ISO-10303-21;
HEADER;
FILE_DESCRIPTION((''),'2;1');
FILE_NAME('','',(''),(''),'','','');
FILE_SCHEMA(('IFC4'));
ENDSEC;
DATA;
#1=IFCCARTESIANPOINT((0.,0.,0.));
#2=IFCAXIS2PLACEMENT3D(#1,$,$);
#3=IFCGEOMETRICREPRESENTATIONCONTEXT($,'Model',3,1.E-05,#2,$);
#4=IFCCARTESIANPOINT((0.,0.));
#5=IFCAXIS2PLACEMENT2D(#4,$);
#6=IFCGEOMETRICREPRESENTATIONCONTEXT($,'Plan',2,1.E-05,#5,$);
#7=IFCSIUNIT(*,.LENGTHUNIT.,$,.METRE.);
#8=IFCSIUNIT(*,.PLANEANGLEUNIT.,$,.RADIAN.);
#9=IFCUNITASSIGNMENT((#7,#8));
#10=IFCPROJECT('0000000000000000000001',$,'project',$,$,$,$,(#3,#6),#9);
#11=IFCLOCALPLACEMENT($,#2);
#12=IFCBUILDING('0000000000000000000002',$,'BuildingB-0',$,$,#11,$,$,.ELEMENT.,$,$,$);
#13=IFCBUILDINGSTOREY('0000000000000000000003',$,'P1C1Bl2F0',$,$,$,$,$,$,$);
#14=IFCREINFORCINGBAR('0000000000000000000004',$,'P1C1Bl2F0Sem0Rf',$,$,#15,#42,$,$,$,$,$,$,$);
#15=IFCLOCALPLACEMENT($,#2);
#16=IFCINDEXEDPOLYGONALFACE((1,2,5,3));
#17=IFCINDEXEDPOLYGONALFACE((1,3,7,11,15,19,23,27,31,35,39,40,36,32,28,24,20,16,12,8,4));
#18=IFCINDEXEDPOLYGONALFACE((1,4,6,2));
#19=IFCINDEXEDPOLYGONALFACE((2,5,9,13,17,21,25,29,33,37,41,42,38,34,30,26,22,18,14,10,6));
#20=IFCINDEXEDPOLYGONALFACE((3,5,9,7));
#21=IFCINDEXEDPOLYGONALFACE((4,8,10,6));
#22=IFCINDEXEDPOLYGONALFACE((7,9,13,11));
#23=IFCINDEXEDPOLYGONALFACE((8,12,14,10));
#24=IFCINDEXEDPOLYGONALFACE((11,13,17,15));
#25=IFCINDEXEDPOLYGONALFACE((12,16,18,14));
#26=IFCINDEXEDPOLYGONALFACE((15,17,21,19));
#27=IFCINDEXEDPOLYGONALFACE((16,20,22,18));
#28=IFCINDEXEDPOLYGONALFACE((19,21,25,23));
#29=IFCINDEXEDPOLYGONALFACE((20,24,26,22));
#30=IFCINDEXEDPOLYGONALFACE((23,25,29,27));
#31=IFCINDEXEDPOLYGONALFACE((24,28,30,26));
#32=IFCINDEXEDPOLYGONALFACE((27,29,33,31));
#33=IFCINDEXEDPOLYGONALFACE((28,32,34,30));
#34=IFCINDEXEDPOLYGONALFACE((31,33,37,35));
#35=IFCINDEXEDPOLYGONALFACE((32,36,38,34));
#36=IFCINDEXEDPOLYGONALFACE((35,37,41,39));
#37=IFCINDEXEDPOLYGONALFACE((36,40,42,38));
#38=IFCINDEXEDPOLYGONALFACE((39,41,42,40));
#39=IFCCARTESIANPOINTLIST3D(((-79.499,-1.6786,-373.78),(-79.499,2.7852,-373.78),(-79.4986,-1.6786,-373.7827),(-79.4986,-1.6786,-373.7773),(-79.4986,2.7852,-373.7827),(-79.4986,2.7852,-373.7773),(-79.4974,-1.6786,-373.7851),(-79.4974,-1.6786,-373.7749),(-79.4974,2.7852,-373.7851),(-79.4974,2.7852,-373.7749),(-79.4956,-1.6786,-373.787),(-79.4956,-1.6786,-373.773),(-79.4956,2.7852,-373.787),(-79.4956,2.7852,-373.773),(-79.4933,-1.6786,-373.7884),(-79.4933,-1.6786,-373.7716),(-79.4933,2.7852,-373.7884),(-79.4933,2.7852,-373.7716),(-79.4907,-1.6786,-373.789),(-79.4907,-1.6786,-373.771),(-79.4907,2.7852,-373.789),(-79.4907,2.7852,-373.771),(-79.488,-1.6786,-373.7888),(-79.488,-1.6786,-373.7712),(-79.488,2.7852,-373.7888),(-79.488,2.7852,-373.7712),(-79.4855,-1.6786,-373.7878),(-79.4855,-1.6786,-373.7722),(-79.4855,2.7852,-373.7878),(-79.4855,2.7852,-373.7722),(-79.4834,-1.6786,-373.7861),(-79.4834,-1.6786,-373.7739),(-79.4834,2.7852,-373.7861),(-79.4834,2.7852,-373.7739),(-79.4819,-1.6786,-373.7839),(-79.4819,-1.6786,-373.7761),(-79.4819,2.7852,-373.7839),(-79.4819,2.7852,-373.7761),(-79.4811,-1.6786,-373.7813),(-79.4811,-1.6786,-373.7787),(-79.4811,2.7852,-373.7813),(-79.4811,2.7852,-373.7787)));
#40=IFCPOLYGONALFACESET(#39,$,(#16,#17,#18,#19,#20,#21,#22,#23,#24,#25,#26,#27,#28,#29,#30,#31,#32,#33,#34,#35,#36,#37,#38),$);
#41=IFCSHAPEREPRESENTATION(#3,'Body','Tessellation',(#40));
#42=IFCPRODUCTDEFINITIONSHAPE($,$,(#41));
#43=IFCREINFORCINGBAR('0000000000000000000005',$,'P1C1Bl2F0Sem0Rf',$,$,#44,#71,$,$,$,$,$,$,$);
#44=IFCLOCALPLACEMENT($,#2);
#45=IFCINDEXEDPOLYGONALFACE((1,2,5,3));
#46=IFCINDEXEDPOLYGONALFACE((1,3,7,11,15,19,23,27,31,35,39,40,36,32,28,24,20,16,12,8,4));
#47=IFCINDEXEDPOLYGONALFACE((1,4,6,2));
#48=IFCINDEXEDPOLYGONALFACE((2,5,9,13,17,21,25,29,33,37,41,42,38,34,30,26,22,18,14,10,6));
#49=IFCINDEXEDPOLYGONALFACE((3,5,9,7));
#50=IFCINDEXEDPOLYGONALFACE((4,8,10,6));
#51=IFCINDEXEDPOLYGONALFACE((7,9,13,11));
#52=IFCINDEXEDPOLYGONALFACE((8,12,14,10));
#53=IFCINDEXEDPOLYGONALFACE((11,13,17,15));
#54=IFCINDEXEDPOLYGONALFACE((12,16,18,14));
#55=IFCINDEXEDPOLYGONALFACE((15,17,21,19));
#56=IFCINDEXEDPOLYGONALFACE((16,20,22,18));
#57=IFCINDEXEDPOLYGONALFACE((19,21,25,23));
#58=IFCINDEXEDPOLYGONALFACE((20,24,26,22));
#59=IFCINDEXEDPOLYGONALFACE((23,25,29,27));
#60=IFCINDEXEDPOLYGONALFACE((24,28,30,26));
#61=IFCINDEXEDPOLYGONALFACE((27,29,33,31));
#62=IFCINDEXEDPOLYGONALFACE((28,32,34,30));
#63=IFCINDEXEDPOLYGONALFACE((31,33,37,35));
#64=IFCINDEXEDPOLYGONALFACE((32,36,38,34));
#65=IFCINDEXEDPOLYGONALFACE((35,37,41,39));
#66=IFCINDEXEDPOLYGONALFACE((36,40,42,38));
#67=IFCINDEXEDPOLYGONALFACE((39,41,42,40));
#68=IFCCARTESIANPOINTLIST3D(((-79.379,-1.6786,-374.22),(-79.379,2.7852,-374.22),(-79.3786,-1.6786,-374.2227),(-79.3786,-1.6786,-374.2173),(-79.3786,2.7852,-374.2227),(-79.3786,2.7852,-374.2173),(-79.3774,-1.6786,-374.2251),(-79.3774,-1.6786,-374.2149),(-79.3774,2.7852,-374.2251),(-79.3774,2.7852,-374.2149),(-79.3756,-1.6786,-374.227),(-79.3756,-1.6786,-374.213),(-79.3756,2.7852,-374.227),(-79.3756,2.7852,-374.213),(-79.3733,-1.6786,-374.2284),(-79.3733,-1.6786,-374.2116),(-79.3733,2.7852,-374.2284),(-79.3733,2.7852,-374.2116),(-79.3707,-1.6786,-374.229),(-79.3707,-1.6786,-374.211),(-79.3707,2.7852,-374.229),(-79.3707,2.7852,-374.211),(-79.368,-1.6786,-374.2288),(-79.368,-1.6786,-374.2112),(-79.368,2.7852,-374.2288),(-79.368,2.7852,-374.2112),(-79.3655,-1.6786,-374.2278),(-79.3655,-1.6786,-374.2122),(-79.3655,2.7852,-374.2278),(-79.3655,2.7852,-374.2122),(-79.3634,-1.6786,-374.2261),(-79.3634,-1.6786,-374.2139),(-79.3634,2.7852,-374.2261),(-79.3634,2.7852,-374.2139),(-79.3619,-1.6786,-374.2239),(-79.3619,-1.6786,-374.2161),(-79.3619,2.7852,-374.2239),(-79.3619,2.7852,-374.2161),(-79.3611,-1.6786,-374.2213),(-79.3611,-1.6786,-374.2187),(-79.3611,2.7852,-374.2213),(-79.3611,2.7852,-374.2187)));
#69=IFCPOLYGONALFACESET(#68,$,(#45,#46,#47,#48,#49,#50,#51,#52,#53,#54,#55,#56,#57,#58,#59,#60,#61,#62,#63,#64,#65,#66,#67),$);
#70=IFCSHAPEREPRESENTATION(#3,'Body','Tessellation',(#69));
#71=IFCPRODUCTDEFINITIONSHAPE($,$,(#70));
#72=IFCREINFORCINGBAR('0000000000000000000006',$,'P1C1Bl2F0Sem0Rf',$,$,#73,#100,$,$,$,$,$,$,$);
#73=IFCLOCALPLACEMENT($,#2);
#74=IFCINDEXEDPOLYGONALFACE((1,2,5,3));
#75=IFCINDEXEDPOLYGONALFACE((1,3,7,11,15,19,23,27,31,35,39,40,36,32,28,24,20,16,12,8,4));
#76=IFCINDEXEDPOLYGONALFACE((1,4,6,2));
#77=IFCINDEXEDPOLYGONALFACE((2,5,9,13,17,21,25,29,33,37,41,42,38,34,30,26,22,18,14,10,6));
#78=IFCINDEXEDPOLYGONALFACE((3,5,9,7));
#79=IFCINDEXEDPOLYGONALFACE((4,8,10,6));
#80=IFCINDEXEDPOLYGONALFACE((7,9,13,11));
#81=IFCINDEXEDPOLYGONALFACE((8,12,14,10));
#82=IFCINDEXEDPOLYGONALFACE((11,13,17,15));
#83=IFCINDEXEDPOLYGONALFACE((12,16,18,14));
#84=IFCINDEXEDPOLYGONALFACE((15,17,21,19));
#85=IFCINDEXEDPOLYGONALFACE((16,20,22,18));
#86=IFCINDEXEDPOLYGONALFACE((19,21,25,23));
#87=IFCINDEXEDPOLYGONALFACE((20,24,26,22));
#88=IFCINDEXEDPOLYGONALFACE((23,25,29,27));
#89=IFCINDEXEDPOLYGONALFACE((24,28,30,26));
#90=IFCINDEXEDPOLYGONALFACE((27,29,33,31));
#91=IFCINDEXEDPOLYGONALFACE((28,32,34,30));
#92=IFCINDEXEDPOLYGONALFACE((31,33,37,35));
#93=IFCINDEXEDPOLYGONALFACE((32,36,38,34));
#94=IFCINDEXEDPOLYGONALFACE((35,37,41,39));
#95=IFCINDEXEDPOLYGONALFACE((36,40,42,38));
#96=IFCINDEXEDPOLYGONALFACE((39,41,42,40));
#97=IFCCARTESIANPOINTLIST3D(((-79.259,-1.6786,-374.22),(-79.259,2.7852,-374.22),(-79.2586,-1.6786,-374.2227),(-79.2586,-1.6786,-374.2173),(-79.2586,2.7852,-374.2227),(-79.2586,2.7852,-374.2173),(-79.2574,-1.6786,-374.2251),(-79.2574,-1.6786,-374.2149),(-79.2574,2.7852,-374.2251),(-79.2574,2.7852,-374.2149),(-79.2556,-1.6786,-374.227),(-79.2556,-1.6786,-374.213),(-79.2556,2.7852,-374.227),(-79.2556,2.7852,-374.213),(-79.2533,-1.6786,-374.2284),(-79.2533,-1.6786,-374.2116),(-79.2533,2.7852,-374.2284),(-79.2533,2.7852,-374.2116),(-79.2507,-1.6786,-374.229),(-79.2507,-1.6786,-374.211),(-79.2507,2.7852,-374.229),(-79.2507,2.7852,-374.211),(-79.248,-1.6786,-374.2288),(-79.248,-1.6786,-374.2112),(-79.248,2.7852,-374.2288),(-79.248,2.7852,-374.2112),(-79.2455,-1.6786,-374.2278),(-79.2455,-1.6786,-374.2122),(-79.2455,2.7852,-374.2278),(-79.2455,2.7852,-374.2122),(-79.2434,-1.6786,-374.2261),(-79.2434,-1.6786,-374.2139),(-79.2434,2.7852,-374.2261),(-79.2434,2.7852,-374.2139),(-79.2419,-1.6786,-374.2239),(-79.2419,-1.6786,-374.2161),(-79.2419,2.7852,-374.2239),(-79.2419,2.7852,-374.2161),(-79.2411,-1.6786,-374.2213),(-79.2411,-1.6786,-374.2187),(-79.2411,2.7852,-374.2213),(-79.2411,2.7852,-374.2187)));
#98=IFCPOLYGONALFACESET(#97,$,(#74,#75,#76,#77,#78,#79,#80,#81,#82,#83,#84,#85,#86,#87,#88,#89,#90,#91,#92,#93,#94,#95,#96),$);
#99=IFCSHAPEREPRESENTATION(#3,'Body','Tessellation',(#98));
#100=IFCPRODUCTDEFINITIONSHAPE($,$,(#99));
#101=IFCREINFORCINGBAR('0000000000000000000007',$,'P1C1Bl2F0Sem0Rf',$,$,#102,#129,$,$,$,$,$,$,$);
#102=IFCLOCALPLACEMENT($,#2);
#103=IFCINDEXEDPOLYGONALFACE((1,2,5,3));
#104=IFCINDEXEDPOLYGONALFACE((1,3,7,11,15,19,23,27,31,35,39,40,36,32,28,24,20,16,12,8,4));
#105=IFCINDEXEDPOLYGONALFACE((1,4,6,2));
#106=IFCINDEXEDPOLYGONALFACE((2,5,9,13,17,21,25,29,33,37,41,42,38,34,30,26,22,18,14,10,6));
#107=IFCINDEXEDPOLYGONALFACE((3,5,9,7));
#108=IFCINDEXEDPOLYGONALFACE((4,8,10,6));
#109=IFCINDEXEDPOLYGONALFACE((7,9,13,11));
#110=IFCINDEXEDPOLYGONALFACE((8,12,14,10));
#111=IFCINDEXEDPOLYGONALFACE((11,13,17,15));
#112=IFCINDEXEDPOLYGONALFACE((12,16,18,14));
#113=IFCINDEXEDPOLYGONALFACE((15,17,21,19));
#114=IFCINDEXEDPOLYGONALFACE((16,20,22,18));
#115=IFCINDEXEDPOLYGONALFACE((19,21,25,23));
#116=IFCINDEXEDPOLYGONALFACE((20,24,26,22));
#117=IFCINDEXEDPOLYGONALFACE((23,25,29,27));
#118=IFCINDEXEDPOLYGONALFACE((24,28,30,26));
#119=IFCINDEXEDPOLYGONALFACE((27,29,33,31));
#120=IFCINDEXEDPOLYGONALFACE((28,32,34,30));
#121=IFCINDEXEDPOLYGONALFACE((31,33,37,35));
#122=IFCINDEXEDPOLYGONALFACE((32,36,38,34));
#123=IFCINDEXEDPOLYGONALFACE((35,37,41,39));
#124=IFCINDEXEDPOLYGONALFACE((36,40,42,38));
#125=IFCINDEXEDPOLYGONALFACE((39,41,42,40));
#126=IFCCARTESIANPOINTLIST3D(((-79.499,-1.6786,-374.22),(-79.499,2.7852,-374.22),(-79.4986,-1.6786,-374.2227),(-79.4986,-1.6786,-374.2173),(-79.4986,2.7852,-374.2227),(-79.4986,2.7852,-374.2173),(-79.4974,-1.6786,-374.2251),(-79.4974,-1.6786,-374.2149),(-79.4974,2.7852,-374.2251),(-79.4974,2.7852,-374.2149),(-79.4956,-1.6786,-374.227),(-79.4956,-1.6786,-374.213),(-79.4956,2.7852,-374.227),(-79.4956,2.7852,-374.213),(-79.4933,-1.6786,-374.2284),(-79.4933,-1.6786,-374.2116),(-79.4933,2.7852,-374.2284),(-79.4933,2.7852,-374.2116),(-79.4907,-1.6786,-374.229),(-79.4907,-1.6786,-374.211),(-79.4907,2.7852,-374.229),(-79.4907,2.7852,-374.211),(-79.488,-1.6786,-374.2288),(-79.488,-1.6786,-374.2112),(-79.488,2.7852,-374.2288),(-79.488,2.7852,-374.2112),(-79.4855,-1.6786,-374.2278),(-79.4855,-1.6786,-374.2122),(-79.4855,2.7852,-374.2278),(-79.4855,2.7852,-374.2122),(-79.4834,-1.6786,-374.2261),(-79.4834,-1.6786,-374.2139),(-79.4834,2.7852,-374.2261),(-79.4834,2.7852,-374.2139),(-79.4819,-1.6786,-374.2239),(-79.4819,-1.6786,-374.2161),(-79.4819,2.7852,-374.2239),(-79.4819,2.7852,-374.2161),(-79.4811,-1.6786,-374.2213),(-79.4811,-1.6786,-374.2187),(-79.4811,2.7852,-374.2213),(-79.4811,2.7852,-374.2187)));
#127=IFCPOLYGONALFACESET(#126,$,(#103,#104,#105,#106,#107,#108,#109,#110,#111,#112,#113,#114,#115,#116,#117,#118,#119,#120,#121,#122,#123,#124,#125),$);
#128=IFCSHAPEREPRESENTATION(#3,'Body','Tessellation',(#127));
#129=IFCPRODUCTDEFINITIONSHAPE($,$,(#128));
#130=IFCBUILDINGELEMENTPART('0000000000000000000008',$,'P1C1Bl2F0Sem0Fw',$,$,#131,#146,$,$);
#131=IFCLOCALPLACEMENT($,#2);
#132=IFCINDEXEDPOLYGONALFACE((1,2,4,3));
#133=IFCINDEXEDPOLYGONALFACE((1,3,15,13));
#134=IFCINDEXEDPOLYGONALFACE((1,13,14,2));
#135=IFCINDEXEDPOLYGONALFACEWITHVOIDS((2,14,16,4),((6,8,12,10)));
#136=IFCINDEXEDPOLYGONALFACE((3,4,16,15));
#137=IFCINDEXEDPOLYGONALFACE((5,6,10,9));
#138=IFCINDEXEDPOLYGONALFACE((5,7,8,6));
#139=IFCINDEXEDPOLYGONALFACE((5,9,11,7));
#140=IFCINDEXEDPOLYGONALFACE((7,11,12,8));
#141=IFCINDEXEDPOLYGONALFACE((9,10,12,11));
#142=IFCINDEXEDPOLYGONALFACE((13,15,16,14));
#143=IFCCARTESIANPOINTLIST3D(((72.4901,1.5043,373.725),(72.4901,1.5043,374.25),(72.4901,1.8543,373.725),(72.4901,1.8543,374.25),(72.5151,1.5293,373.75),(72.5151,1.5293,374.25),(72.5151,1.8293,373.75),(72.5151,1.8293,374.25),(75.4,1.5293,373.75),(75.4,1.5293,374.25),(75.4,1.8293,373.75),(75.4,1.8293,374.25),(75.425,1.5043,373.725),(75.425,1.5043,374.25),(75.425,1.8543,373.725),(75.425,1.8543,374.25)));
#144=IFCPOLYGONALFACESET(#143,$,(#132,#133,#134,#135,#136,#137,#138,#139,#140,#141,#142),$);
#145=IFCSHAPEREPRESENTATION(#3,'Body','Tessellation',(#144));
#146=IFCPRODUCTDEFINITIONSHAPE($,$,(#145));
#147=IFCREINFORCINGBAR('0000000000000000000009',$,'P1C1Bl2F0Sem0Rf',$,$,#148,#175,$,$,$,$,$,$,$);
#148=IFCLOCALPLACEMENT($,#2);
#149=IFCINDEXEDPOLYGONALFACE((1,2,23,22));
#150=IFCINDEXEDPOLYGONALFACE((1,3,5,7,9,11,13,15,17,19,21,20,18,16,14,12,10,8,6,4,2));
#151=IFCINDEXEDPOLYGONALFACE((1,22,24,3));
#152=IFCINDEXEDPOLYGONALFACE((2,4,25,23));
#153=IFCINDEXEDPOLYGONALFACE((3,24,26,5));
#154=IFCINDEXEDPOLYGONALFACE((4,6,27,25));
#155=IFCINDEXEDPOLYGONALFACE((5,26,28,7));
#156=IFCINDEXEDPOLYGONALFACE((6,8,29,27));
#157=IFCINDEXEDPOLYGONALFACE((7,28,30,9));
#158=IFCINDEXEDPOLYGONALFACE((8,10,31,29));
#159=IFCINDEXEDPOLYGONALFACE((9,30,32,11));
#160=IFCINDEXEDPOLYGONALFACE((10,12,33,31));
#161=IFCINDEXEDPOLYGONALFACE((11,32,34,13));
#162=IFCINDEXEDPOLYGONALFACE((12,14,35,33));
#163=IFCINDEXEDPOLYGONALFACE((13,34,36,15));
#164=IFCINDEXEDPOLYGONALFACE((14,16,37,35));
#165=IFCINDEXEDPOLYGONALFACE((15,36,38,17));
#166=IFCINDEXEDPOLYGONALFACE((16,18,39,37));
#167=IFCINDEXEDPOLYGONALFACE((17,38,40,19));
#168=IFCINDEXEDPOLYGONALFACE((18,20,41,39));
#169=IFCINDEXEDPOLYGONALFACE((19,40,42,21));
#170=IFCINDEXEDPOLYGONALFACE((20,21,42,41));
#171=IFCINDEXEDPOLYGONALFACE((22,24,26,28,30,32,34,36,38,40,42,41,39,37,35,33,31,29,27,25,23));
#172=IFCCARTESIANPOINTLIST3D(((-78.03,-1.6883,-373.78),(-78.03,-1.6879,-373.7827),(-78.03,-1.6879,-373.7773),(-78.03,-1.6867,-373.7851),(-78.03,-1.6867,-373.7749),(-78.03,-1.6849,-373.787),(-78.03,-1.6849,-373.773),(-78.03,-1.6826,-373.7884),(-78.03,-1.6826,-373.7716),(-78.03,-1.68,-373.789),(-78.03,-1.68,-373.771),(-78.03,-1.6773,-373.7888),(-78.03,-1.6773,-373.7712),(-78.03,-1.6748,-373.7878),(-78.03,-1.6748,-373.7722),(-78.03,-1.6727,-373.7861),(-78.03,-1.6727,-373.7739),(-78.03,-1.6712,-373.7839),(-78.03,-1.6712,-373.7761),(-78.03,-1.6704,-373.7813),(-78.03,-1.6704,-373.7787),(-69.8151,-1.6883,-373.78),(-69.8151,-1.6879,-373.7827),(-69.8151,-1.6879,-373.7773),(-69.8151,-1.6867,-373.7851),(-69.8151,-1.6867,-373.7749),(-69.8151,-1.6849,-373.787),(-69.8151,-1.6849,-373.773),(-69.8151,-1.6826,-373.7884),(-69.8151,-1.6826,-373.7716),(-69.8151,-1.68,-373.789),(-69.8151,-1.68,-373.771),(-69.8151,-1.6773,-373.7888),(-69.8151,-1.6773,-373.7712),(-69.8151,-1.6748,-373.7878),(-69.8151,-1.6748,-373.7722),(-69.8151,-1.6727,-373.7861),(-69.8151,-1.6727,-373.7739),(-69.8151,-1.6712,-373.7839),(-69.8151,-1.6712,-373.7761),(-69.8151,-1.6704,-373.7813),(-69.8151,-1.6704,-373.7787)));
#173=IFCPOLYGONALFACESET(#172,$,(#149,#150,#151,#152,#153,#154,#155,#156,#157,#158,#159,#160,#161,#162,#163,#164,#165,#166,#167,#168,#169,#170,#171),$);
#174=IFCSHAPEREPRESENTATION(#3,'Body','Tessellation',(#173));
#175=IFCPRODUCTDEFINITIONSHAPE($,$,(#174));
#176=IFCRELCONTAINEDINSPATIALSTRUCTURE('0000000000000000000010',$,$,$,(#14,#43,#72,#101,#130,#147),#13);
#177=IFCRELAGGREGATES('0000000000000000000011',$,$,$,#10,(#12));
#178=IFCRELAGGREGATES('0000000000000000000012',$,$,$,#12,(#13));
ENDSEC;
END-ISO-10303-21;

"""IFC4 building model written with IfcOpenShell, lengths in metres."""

from ifc_helpers import new_model, entity, si_unit, origin, origin_2d, place, context, project, spatial, polyline, outline, extrude, element, save


model = new_model("IFC4")

# Units and contexts
model_context = context("Model", 3, precision=1e-05, world=origin())
plan_context = context("Plan", 2, precision=1e-05, world=origin_2d())
ifc_project = project(units=[si_unit("LENGTHUNIT", "METRE"), si_unit("PLANEANGLEUNIT", "RADIAN")], contexts=[model_context, plan_context])

# Building, storey
building_placement = place(None, origin())
building = spatial("IfcBuilding", under=ifc_project, at=building_placement, Name="BuildingB-0", CompositionType="ELEMENT")
storey = spatial("IfcBuildingStorey", under=building, Name="P1C1Bl2F0")

# Reinforcing bars
element("IfcReinforcingBar", 1, inside=storey, Name="P1C1Bl2F0Sem0Rf", context=model_context, shape_type="SweptSolid", body=[
    entity("IfcSurfaceCurveSweptAreaSolid", entity("IfcCircleProfileDef", "AREA", None, None, 0.009), None, entity("IfcPolyline", [entity("IfcCartesianPoint", [79.49, 1.6786, 373.78]), entity("IfcCartesianPoint", [79.49, -2.7852, 373.78])]), None, None, entity("IfcPlane", entity("IfcAxis2Placement3D", entity("IfcCartesianPoint", [79.49, 1.6786, 373.78]), entity("IfcDirection", [0.0, 0.0, 1.0]), entity("IfcDirection", [1.0, 0.0, 0.0])))),
])
element("IfcReinforcingBar", 2, inside=storey, Name="P1C1Bl2F0Sem0Rf", context=model_context, shape_type="SweptSolid", body=[
    entity("IfcSurfaceCurveSweptAreaSolid", entity("IfcCircleProfileDef", "AREA", None, None, 0.009), None, entity("IfcPolyline", [entity("IfcCartesianPoint", [79.37, 1.6786, 374.22]), entity("IfcCartesianPoint", [79.37, -2.7852, 374.22])]), None, None, entity("IfcPlane", entity("IfcAxis2Placement3D", entity("IfcCartesianPoint", [79.37, 1.6786, 374.22]), entity("IfcDirection", [0.0, 0.0, 1.0]), entity("IfcDirection", [1.0, 0.0, 0.0])))),
])
element("IfcReinforcingBar", 3, inside=storey, Name="P1C1Bl2F0Sem0Rf", context=model_context, shape_type="SweptSolid", body=[
    entity("IfcSurfaceCurveSweptAreaSolid", entity("IfcCircleProfileDef", "AREA", None, None, 0.009), None, entity("IfcPolyline", [entity("IfcCartesianPoint", [79.25, 1.6786, 374.22]), entity("IfcCartesianPoint", [79.25, -2.7852, 374.22])]), None, None, entity("IfcPlane", entity("IfcAxis2Placement3D", entity("IfcCartesianPoint", [79.25, 1.6786, 374.22]), entity("IfcDirection", [0.0, 0.0, 1.0]), entity("IfcDirection", [1.0, 0.0, 0.0])))),
])
element("IfcReinforcingBar", 4, inside=storey, Name="P1C1Bl2F0Sem0Rf", context=model_context, shape_type="SweptSolid", body=[
    entity("IfcSurfaceCurveSweptAreaSolid", entity("IfcCircleProfileDef", "AREA", None, None, 0.009), None, entity("IfcPolyline", [entity("IfcCartesianPoint", [79.49, 1.6786, 374.22]), entity("IfcCartesianPoint", [79.49, -2.7852, 374.22])]), None, None, entity("IfcPlane", entity("IfcAxis2Placement3D", entity("IfcCartesianPoint", [79.49, 1.6786, 374.22]), entity("IfcDirection", [0.0, 0.0, 1.0]), entity("IfcDirection", [1.0, 0.0, 0.0])))),
])

# Building element part, opening
building_element_part_1 = element("IfcBuildingElementPart", 5, inside=storey, Name="P1C1Bl2F0Sem0Fw", context=model_context, shape_type="SweptSolid", body=[
    extrude(outline(polyline([(75.425, 1.5043, 373.725), (75.425, 1.8543, 373.725), (72.4901, 1.8543, 373.725), (72.4901, 1.5043, 373.725), (75.425, 1.5043, 373.725)])), None, (0.0, 0.0, 1.0), 0.525),
])
element("IfcOpeningElement", 6, inside=storey, cuts=building_element_part_1, context=model_context, shape_type="SweptSolid", body=[
    extrude(outline(polyline([(75.4, 1.5293, 373.75), (75.4, 1.8293, 373.75), (72.5151, 1.8293, 373.75), (72.5151, 1.5293, 373.75), (75.4, 1.5293, 373.75)])), None, (0.0, 0.0, 1.0), 0.5),
])

# Reinforcing bar
element("IfcReinforcingBar", 7, inside=storey, Name="P1C1Bl2F0Sem0Rf", context=model_context, shape_type="SweptSolid", body=[
    entity("IfcSurfaceCurveSweptAreaSolid", entity("IfcCircleProfileDef", "AREA", None, None, 0.009), None, entity("IfcPolyline", [entity("IfcCartesianPoint", [78.03, 1.6793, 373.78]), entity("IfcCartesianPoint", [69.8151, 1.6793, 373.78])]), None, None, entity("IfcPlane", entity("IfcAxis2Placement3D", entity("IfcCartesianPoint", [78.03, 1.6793, 373.78]), entity("IfcDirection", [0.0, 0.0, 1.0]), entity("IfcDirection", [1.0, 0.0, 0.0])))),
])

save(model, "model.ifc")
